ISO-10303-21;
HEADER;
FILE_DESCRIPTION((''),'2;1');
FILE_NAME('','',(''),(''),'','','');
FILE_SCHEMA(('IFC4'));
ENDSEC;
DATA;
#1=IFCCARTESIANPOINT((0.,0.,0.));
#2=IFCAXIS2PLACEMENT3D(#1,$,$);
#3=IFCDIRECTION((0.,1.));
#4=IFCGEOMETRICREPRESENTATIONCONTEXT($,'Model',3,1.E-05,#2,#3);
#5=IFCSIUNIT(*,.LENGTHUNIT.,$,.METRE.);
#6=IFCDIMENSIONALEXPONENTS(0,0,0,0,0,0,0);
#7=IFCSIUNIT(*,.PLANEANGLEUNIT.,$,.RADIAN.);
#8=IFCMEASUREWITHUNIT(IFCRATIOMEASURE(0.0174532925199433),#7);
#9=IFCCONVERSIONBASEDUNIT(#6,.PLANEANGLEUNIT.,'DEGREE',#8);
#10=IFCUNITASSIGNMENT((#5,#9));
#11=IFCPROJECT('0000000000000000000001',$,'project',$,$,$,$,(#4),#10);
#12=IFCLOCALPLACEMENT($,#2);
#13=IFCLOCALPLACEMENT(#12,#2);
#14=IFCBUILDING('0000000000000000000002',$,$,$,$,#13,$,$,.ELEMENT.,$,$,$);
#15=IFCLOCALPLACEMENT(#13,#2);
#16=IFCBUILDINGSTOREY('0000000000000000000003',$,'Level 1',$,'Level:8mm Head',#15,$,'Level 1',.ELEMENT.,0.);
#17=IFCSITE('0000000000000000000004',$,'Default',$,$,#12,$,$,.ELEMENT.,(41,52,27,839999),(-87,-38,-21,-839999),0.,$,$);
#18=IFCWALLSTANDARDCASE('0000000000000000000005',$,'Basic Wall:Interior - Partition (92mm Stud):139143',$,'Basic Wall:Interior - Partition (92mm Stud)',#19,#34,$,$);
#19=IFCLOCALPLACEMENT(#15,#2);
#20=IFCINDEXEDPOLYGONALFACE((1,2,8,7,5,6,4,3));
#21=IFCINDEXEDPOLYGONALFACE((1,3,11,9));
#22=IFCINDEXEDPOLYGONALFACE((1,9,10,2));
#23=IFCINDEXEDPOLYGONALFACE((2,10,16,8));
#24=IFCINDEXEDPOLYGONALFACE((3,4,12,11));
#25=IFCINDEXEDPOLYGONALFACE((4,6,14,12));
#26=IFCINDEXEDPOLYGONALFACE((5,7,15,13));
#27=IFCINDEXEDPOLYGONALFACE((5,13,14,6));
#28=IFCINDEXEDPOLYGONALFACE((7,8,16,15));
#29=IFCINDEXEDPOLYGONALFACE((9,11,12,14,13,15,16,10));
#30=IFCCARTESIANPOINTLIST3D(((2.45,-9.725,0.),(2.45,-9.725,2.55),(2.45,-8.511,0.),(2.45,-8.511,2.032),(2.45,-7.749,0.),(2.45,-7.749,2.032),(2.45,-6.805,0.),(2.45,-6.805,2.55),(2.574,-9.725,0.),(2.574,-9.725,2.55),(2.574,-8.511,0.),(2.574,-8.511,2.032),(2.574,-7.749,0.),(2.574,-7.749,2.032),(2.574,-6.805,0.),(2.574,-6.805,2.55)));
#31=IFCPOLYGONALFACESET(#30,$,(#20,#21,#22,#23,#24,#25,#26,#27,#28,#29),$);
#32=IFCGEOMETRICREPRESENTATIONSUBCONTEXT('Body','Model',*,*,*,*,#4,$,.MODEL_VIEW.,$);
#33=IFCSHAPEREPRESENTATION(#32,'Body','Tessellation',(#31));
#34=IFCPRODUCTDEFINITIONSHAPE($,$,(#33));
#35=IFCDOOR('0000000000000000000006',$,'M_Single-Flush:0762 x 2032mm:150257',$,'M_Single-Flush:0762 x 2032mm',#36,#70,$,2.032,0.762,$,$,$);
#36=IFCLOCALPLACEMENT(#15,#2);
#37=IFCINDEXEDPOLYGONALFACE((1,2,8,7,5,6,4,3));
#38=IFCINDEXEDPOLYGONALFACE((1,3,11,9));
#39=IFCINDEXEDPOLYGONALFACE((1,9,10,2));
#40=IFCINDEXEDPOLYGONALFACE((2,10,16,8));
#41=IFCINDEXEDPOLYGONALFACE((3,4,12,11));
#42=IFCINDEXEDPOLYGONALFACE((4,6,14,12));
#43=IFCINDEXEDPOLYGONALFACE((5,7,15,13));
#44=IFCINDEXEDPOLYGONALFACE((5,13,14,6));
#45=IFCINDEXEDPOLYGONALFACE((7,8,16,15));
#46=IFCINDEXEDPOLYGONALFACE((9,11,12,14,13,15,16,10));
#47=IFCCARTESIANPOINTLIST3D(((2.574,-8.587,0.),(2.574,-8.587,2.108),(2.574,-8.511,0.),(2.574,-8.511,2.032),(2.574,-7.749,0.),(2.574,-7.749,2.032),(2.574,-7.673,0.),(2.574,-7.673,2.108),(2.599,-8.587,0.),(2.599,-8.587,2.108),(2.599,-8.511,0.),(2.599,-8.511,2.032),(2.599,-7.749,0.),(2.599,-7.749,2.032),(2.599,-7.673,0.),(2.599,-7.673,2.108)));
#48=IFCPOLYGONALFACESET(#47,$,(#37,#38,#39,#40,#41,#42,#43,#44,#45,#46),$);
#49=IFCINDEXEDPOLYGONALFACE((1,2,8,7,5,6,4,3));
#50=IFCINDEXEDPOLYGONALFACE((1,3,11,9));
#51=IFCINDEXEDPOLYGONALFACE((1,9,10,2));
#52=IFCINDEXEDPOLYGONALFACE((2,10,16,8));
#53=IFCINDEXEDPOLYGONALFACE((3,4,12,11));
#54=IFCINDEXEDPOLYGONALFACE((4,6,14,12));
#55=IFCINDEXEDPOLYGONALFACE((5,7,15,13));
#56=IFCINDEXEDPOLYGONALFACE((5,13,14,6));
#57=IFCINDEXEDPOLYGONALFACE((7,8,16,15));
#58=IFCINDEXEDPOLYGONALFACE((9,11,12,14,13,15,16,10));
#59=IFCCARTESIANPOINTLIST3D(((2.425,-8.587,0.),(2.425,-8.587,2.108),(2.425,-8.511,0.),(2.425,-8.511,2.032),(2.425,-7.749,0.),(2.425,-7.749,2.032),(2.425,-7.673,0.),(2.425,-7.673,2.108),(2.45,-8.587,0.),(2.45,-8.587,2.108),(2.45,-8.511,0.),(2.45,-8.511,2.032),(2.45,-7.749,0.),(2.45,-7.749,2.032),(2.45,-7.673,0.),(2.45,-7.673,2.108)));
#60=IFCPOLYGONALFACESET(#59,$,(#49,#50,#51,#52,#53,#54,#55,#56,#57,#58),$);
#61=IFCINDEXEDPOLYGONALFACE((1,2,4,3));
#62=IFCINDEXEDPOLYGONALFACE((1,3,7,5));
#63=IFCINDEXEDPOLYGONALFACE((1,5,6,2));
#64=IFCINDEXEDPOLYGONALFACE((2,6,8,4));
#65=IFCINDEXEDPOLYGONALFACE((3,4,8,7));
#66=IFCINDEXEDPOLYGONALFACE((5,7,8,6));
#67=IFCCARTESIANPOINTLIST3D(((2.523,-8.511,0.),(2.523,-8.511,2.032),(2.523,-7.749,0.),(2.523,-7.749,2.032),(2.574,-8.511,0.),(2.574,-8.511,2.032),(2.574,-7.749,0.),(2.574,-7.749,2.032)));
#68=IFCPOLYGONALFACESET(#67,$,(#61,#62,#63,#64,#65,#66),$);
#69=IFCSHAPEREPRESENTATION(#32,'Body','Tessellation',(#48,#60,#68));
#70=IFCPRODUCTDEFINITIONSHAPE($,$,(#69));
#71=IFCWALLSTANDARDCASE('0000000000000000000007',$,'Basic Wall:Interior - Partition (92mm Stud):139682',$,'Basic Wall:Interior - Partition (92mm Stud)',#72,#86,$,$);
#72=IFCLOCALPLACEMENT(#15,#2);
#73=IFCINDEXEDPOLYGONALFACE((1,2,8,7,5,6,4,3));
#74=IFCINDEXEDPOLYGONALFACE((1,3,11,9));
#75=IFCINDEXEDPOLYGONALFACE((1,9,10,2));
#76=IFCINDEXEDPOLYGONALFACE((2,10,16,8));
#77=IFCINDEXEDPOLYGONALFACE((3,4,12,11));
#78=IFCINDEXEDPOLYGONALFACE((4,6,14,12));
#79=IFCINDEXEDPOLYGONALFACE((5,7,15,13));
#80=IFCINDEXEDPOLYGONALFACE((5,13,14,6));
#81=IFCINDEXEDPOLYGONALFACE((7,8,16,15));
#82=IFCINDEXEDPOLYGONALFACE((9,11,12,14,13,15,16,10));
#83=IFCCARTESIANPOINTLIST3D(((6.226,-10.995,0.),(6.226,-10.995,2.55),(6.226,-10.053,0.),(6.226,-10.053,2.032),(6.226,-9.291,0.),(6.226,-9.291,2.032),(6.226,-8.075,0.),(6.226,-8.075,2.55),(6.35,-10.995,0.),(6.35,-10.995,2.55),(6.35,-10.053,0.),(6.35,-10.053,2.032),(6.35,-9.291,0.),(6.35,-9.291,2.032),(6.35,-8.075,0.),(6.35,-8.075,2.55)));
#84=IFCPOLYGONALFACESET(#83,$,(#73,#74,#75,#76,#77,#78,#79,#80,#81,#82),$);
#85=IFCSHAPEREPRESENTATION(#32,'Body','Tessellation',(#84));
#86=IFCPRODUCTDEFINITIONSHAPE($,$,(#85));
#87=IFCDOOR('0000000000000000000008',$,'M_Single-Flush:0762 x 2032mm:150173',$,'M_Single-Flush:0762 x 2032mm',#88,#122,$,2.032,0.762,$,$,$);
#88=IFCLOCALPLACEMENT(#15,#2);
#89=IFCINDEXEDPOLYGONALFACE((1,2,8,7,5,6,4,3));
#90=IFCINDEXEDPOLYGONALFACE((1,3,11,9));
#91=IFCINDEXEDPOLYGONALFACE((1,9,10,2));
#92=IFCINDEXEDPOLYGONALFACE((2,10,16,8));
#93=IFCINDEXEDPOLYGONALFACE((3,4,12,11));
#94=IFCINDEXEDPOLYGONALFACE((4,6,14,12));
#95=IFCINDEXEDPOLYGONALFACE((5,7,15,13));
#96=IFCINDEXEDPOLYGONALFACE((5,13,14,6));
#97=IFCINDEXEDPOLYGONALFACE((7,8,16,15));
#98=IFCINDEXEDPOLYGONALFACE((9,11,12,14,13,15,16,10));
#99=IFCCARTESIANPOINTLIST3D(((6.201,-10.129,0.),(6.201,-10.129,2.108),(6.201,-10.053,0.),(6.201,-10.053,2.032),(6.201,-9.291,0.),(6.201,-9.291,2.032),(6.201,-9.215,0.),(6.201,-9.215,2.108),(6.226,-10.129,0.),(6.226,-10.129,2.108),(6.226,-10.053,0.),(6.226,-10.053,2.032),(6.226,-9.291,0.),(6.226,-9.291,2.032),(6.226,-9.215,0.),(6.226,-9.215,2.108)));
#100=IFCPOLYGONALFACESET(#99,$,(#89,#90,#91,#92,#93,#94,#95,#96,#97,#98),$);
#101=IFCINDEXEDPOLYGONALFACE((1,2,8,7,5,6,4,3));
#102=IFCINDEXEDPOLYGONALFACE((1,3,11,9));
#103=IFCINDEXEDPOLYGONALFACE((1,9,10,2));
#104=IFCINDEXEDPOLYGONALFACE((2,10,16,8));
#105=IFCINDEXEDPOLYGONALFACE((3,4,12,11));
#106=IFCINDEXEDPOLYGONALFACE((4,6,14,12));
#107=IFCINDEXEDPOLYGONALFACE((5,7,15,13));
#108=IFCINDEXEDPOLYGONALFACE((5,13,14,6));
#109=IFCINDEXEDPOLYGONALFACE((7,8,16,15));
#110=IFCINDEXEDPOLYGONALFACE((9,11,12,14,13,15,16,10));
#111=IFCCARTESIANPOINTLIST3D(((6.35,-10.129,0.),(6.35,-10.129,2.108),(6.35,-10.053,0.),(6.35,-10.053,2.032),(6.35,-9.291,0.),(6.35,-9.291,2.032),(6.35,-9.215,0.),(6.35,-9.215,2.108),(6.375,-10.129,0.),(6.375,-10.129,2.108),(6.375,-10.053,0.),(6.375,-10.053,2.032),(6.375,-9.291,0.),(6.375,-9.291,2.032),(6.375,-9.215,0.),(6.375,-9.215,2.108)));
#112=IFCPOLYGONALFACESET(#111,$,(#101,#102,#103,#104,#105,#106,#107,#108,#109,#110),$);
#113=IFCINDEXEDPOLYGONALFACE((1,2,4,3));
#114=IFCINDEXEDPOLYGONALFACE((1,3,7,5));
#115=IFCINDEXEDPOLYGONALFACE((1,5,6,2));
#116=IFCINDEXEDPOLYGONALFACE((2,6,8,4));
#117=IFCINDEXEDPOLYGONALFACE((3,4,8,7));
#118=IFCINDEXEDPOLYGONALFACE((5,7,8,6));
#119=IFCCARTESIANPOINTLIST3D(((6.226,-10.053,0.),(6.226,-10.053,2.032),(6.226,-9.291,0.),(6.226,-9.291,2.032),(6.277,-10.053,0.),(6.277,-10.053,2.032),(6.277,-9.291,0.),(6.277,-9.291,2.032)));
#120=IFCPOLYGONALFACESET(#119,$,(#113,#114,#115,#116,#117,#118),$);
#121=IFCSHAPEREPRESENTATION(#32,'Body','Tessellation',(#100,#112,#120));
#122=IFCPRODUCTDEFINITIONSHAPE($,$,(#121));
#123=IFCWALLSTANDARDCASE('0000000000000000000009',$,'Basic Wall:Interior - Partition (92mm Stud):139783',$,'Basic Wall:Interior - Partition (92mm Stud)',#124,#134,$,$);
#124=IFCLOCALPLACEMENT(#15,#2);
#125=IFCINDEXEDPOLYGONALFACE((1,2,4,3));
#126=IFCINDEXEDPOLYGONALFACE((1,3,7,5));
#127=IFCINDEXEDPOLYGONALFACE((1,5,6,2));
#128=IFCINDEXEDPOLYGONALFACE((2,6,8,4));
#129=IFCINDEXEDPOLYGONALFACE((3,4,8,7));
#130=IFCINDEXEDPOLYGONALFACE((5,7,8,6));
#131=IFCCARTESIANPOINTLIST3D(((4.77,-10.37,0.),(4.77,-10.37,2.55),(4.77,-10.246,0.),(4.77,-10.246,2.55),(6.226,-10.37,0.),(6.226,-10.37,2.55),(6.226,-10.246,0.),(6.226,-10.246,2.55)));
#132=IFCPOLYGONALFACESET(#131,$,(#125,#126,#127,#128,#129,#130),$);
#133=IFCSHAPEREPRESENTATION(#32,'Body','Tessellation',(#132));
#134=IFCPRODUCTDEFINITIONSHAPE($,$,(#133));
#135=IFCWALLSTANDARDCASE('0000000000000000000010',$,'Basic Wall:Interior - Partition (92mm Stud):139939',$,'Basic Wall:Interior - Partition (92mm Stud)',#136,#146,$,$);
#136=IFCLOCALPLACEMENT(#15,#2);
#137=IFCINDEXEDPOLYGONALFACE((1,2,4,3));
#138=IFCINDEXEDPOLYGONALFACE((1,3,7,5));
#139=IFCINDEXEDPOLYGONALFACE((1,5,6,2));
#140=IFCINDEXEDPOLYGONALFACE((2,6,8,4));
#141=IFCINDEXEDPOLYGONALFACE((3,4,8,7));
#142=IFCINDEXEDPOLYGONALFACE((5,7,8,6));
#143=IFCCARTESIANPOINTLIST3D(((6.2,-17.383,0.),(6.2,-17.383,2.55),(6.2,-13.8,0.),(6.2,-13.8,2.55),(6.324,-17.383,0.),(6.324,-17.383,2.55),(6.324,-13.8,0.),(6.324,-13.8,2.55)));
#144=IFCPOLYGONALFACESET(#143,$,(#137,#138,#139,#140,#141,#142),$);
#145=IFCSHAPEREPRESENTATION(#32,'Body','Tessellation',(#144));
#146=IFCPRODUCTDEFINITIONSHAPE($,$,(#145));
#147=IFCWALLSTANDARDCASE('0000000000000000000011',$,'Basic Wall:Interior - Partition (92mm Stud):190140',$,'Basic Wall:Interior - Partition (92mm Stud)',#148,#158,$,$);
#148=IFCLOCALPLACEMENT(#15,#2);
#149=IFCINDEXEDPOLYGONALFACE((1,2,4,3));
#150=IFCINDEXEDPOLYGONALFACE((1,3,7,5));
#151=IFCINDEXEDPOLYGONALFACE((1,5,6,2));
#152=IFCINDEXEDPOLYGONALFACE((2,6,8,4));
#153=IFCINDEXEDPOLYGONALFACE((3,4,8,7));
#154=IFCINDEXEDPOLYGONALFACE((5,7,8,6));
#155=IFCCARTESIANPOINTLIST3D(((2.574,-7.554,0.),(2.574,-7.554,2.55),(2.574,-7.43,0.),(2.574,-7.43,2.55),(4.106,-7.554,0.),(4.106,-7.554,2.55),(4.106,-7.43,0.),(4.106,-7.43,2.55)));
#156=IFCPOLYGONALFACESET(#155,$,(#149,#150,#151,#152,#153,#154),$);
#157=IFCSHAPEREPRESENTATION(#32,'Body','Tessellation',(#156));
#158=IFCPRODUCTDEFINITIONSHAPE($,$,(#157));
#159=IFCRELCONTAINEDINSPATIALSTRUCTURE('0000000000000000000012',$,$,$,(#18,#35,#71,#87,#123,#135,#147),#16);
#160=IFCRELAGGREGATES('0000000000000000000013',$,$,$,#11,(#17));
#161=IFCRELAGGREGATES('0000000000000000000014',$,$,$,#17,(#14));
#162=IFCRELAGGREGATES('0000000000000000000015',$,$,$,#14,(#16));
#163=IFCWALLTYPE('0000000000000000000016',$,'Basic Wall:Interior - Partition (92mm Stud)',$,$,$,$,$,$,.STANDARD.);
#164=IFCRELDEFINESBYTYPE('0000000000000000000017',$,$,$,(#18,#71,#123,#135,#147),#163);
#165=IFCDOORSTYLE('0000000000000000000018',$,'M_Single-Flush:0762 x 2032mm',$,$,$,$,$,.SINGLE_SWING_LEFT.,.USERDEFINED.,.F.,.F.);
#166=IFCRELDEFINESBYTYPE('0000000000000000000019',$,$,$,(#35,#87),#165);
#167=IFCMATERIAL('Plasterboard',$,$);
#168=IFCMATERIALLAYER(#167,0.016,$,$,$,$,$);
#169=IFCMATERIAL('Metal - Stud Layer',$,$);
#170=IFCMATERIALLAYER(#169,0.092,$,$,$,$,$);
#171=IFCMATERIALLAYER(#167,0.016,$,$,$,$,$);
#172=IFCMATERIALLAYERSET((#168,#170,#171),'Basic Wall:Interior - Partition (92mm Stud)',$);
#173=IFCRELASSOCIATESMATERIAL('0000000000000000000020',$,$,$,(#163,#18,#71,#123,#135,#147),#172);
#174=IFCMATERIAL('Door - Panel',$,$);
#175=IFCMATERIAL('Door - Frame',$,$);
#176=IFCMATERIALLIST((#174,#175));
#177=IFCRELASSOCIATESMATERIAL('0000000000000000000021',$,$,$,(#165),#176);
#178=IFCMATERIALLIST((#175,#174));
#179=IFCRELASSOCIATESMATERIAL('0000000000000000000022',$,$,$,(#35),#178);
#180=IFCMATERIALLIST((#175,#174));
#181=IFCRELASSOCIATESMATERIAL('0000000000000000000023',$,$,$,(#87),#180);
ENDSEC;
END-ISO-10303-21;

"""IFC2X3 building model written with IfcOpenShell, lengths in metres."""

from ifc_helpers import new_model, entity, si_unit, converted_unit, direction, frame, frame_2d, origin, place, context, subcontext, project, spatial, polyline, rectangle, outline, extrude, source, transform, mapped, material, material_list, layer, layer_set, layer_usage, type_object, type_shapes, element, fill, save


model = new_model("IFC2X3")

# Units and contexts
model_context = context("Model", 3, precision=1e-05, world=origin(), true_north=direction((0.0, 1.0)))
body_context = subcontext(model_context, "Body", "Model", "MODEL_VIEW")
ifc_project = project(units=[si_unit("LENGTHUNIT", "METRE"), converted_unit("PLANEANGLEUNIT", "DEGREE", entity("IfcRatioMeasure", 0.0174532925199433), si_unit("PLANEANGLEUNIT", "RADIAN"), dimensions=[0, 0, 0, 0, 0, 0, 0])], contexts=[model_context])

# Site, building, storey
site_placement = place(None, origin())
site = spatial("IfcSite", under=ifc_project, at=site_placement, Name="Default", CompositionType="ELEMENT", RefLatitude=(41, 52, 27, 839999), RefLongitude=(-87, -38, -21, -839999), RefElevation=0.0)
building_placement = place(site_placement, origin())
building = spatial("IfcBuilding", under=site, at=building_placement, CompositionType="ELEMENT")
storey_placement = place(building_placement, origin())
storey = spatial("IfcBuildingStorey", under=building, at=storey_placement, Name="Level 1", ObjectType="Level:8mm Head", LongName="Level 1", CompositionType="ELEMENT", Elevation=0.0)

# Shared definitions
ifc_material_1 = material(Name="Metal - Stud Layer")
ifc_material_2 = material(Name="Plasterboard")
ifc_material_3 = material(Name="Door - Frame")
ifc_material_4 = material(Name="Door - Panel")

# Walls, openings, doors
ifc_layer_1 = layer(ifc_material_2, 0.016)
ifc_layer_2 = layer(ifc_material_1, 0.092)
ifc_layer_3 = layer(ifc_material_2, 0.016)
ifc_layer_set_1 = layer_set([ifc_layer_1, ifc_layer_2, ifc_layer_3], Name="Basic Wall:Interior - Partition (92mm Stud)")
ifc_layer_usage_1 = layer_usage(ifc_layer_set_1, "AXIS2", "NEGATIVE", 0.062)
wall_type_1 = type_object("IfcWallType", Name="Basic Wall:Interior - Partition (92mm Stud)", PredefinedType="STANDARD", material=ifc_layer_set_1)
wall_1_placement = place(storey_placement, frame((2.512, -6.805, 0.0), z_axis=(0.0, 0.0, 1.0), x_axis=(0.0, -1.0, 0.0)))
wall_1 = element("IfcWallStandardCase", 1, at=wall_1_placement, inside=storey, type_object=wall_type_1, material=ifc_layer_usage_1, Name="Basic Wall:Interior - Partition (92mm Stud):139143", ObjectType="Basic Wall:Interior - Partition (92mm Stud)", context=body_context, shape_type="SweptSolid", body=[
    extrude(rectangle(XDim=2.92, YDim=0.124, at=frame_2d((1.46, 0.0), x_axis=(-1.0, 0.0))), origin(), (0.0, 0.0, 1.0), 2.55),
])
opening_1_placement = place(wall_1_placement, frame((0.944, -0.062, 0.0)))
opening_1 = element("IfcOpeningElement", 2, at=opening_1_placement, cuts=wall_1, ObjectType="Opening", context=body_context, shape_type="SweptSolid", body=[
    extrude(rectangle(XDim=0.762, YDim=2.032, at=frame_2d((1.016, 0.381), x_axis=(0.0, -1.0))), frame((0.0, 0.0, 0.0), z_axis=(0.0, 1.0, 0.0), x_axis=(0.0, 0.0, 1.0)), (0.0, 0.0, 1.0), 0.124),
])
ifc_material_list_1 = material_list([ifc_material_3, ifc_material_4])
ifc_material_list_2 = material_list([ifc_material_4, ifc_material_3])
door_style_1 = type_object("IfcDoorStyle", Name="M_Single-Flush:0762 x 2032mm", ConstructionType="USERDEFINED", OperationType="SINGLE_SWING_LEFT", ParameterTakesPrecedence=False, Sizeable=False, material=ifc_material_list_2)
shared_shape_1 = source(origin(), body_context, "Body", "SweptSolid", [
    extrude(outline(polyline([(-0.457, -1.073), (0.457, -1.073), (0.457, 1.035), (0.381, 1.035), (0.381, -0.997), (-0.381, -0.997), (-0.381, 1.035), (-0.457, 1.035), (-0.457, -1.073)])), frame((0.381, 0.149, 1.035), z_axis=(0.0, -1.0, 0.0), x_axis=(-1.0, 0.0, 0.0)), (0.0, 0.0, 1.0), 0.025),
    extrude(outline(polyline([(-1.073, -0.457), (1.035, -0.457), (1.035, -0.381), (-0.997, -0.381), (-0.997, 0.381), (1.035, 0.381), (1.035, 0.457), (-1.073, 0.457), (-1.073, -0.457)])), frame((0.381, 0.0, 1.035), z_axis=(0.0, -1.0, 0.0), x_axis=(0.0, 0.0, -1.0)), (0.0, 0.0, 1.0), 0.025),
    extrude(rectangle(XDim=0.762, YDim=0.051, at=frame_2d((0.0, 0.0), x_axis=(1.0, 0.0))), frame((0.381, 0.0985, 0.0)), (0.0, 0.0, 1.0), 2.032),
])
type_shapes(door_style_1, [shared_shape_1])
door_1_placement = place(opening_1_placement, origin())
door_1 = element("IfcDoor", 3, at=door_1_placement, inside=storey, type_object=door_style_1, material=ifc_material_list_1, Name="M_Single-Flush:0762 x 2032mm:150257", ObjectType="M_Single-Flush:0762 x 2032mm", OverallHeight=2.032, OverallWidth=0.762, context=body_context, shape_type="MappedRepresentation", body=[
    mapped(shared_shape_1, transform((0.0, 0.0, 0.0), scale=1.0)),
])
fill(opening_1, door_1)
ifc_layer_usage_2 = layer_usage(ifc_layer_set_1, "AXIS2", "NEGATIVE", 0.062)
wall_2_placement = place(storey_placement, frame((6.288, -10.995, 0.0), z_axis=(0.0, 0.0, 1.0), x_axis=(0.0, 1.0, 0.0)))
wall_2 = element("IfcWallStandardCase", 4, at=wall_2_placement, inside=storey, type_object=wall_type_1, material=ifc_layer_usage_2, Name="Basic Wall:Interior - Partition (92mm Stud):139682", ObjectType="Basic Wall:Interior - Partition (92mm Stud)", context=body_context, shape_type="SweptSolid", body=[
    extrude(rectangle(XDim=2.92, YDim=0.124, at=frame_2d((1.46, 0.0), x_axis=(-1.0, 0.0))), origin(), (0.0, 0.0, 1.0), 2.55),
])
opening_2_placement = place(wall_2_placement, frame((0.942, -0.062, 0.0)))
opening_2 = element("IfcOpeningElement", 5, at=opening_2_placement, cuts=wall_2, ObjectType="Opening", context=body_context, shape_type="SweptSolid", body=[
    extrude(rectangle(XDim=0.762, YDim=2.032, at=frame_2d((1.016, 0.381), x_axis=(0.0, -1.0))), frame((0.0, 0.0, 0.0), z_axis=(0.0, 1.0, 0.0), x_axis=(0.0, 0.0, 1.0)), (0.0, 0.0, 1.0), 0.124),
])
ifc_material_list_3 = material_list([ifc_material_3, ifc_material_4])
door_2_placement = place(opening_2_placement, origin())
door_2 = element("IfcDoor", 6, at=door_2_placement, inside=storey, type_object=door_style_1, material=ifc_material_list_3, Name="M_Single-Flush:0762 x 2032mm:150173", ObjectType="M_Single-Flush:0762 x 2032mm", OverallHeight=2.032, OverallWidth=0.762, context=body_context, shape_type="MappedRepresentation", body=[
    mapped(shared_shape_1, transform((0.0, 0.0, 0.0), scale=1.0)),
])
fill(opening_2, door_2)

# Walls
ifc_layer_usage_3 = layer_usage(ifc_layer_set_1, "AXIS2", "NEGATIVE", 0.062)
wall_3_placement = place(storey_placement, frame((4.77, -10.308, 0.0)))
element("IfcWallStandardCase", 7, at=wall_3_placement, inside=storey, type_object=wall_type_1, material=ifc_layer_usage_3, Name="Basic Wall:Interior - Partition (92mm Stud):139783", ObjectType="Basic Wall:Interior - Partition (92mm Stud)", context=body_context, shape_type="SweptSolid", body=[
    extrude(rectangle(XDim=1.456, YDim=0.124, at=frame_2d((0.728, 0.0), x_axis=(-1.0, 0.0))), origin(), (0.0, 0.0, 1.0), 2.55),
])
ifc_layer_usage_4 = layer_usage(ifc_layer_set_1, "AXIS2", "NEGATIVE", 0.062)
wall_4_placement = place(storey_placement, frame((6.262, -13.8, 0.0), z_axis=(0.0, 0.0, 1.0), x_axis=(0.0, -1.0, 0.0)))
element("IfcWallStandardCase", 8, at=wall_4_placement, inside=storey, type_object=wall_type_1, material=ifc_layer_usage_4, Name="Basic Wall:Interior - Partition (92mm Stud):139939", ObjectType="Basic Wall:Interior - Partition (92mm Stud)", context=body_context, shape_type="SweptSolid", body=[
    extrude(rectangle(XDim=3.583, YDim=0.124, at=frame_2d((1.7915, 0.0), x_axis=(-1.0, 0.0))), origin(), (0.0, 0.0, 1.0), 2.55),
])
ifc_layer_usage_5 = layer_usage(ifc_layer_set_1, "AXIS2", "NEGATIVE", 0.062)
wall_5_placement = place(storey_placement, frame((4.106, -7.492, 0.0), z_axis=(0.0, 0.0, 1.0), x_axis=(-1.0, 0.0, 0.0)))
element("IfcWallStandardCase", 9, at=wall_5_placement, inside=storey, type_object=wall_type_1, material=ifc_layer_usage_5, Name="Basic Wall:Interior - Partition (92mm Stud):190140", ObjectType="Basic Wall:Interior - Partition (92mm Stud)", context=body_context, shape_type="SweptSolid", body=[
    extrude(rectangle(XDim=1.532, YDim=0.124, at=frame_2d((0.766, 0.0), x_axis=(-1.0, 0.0))), origin(), (0.0, 0.0, 1.0), 2.55),
])

save(model, "model.ifc")
